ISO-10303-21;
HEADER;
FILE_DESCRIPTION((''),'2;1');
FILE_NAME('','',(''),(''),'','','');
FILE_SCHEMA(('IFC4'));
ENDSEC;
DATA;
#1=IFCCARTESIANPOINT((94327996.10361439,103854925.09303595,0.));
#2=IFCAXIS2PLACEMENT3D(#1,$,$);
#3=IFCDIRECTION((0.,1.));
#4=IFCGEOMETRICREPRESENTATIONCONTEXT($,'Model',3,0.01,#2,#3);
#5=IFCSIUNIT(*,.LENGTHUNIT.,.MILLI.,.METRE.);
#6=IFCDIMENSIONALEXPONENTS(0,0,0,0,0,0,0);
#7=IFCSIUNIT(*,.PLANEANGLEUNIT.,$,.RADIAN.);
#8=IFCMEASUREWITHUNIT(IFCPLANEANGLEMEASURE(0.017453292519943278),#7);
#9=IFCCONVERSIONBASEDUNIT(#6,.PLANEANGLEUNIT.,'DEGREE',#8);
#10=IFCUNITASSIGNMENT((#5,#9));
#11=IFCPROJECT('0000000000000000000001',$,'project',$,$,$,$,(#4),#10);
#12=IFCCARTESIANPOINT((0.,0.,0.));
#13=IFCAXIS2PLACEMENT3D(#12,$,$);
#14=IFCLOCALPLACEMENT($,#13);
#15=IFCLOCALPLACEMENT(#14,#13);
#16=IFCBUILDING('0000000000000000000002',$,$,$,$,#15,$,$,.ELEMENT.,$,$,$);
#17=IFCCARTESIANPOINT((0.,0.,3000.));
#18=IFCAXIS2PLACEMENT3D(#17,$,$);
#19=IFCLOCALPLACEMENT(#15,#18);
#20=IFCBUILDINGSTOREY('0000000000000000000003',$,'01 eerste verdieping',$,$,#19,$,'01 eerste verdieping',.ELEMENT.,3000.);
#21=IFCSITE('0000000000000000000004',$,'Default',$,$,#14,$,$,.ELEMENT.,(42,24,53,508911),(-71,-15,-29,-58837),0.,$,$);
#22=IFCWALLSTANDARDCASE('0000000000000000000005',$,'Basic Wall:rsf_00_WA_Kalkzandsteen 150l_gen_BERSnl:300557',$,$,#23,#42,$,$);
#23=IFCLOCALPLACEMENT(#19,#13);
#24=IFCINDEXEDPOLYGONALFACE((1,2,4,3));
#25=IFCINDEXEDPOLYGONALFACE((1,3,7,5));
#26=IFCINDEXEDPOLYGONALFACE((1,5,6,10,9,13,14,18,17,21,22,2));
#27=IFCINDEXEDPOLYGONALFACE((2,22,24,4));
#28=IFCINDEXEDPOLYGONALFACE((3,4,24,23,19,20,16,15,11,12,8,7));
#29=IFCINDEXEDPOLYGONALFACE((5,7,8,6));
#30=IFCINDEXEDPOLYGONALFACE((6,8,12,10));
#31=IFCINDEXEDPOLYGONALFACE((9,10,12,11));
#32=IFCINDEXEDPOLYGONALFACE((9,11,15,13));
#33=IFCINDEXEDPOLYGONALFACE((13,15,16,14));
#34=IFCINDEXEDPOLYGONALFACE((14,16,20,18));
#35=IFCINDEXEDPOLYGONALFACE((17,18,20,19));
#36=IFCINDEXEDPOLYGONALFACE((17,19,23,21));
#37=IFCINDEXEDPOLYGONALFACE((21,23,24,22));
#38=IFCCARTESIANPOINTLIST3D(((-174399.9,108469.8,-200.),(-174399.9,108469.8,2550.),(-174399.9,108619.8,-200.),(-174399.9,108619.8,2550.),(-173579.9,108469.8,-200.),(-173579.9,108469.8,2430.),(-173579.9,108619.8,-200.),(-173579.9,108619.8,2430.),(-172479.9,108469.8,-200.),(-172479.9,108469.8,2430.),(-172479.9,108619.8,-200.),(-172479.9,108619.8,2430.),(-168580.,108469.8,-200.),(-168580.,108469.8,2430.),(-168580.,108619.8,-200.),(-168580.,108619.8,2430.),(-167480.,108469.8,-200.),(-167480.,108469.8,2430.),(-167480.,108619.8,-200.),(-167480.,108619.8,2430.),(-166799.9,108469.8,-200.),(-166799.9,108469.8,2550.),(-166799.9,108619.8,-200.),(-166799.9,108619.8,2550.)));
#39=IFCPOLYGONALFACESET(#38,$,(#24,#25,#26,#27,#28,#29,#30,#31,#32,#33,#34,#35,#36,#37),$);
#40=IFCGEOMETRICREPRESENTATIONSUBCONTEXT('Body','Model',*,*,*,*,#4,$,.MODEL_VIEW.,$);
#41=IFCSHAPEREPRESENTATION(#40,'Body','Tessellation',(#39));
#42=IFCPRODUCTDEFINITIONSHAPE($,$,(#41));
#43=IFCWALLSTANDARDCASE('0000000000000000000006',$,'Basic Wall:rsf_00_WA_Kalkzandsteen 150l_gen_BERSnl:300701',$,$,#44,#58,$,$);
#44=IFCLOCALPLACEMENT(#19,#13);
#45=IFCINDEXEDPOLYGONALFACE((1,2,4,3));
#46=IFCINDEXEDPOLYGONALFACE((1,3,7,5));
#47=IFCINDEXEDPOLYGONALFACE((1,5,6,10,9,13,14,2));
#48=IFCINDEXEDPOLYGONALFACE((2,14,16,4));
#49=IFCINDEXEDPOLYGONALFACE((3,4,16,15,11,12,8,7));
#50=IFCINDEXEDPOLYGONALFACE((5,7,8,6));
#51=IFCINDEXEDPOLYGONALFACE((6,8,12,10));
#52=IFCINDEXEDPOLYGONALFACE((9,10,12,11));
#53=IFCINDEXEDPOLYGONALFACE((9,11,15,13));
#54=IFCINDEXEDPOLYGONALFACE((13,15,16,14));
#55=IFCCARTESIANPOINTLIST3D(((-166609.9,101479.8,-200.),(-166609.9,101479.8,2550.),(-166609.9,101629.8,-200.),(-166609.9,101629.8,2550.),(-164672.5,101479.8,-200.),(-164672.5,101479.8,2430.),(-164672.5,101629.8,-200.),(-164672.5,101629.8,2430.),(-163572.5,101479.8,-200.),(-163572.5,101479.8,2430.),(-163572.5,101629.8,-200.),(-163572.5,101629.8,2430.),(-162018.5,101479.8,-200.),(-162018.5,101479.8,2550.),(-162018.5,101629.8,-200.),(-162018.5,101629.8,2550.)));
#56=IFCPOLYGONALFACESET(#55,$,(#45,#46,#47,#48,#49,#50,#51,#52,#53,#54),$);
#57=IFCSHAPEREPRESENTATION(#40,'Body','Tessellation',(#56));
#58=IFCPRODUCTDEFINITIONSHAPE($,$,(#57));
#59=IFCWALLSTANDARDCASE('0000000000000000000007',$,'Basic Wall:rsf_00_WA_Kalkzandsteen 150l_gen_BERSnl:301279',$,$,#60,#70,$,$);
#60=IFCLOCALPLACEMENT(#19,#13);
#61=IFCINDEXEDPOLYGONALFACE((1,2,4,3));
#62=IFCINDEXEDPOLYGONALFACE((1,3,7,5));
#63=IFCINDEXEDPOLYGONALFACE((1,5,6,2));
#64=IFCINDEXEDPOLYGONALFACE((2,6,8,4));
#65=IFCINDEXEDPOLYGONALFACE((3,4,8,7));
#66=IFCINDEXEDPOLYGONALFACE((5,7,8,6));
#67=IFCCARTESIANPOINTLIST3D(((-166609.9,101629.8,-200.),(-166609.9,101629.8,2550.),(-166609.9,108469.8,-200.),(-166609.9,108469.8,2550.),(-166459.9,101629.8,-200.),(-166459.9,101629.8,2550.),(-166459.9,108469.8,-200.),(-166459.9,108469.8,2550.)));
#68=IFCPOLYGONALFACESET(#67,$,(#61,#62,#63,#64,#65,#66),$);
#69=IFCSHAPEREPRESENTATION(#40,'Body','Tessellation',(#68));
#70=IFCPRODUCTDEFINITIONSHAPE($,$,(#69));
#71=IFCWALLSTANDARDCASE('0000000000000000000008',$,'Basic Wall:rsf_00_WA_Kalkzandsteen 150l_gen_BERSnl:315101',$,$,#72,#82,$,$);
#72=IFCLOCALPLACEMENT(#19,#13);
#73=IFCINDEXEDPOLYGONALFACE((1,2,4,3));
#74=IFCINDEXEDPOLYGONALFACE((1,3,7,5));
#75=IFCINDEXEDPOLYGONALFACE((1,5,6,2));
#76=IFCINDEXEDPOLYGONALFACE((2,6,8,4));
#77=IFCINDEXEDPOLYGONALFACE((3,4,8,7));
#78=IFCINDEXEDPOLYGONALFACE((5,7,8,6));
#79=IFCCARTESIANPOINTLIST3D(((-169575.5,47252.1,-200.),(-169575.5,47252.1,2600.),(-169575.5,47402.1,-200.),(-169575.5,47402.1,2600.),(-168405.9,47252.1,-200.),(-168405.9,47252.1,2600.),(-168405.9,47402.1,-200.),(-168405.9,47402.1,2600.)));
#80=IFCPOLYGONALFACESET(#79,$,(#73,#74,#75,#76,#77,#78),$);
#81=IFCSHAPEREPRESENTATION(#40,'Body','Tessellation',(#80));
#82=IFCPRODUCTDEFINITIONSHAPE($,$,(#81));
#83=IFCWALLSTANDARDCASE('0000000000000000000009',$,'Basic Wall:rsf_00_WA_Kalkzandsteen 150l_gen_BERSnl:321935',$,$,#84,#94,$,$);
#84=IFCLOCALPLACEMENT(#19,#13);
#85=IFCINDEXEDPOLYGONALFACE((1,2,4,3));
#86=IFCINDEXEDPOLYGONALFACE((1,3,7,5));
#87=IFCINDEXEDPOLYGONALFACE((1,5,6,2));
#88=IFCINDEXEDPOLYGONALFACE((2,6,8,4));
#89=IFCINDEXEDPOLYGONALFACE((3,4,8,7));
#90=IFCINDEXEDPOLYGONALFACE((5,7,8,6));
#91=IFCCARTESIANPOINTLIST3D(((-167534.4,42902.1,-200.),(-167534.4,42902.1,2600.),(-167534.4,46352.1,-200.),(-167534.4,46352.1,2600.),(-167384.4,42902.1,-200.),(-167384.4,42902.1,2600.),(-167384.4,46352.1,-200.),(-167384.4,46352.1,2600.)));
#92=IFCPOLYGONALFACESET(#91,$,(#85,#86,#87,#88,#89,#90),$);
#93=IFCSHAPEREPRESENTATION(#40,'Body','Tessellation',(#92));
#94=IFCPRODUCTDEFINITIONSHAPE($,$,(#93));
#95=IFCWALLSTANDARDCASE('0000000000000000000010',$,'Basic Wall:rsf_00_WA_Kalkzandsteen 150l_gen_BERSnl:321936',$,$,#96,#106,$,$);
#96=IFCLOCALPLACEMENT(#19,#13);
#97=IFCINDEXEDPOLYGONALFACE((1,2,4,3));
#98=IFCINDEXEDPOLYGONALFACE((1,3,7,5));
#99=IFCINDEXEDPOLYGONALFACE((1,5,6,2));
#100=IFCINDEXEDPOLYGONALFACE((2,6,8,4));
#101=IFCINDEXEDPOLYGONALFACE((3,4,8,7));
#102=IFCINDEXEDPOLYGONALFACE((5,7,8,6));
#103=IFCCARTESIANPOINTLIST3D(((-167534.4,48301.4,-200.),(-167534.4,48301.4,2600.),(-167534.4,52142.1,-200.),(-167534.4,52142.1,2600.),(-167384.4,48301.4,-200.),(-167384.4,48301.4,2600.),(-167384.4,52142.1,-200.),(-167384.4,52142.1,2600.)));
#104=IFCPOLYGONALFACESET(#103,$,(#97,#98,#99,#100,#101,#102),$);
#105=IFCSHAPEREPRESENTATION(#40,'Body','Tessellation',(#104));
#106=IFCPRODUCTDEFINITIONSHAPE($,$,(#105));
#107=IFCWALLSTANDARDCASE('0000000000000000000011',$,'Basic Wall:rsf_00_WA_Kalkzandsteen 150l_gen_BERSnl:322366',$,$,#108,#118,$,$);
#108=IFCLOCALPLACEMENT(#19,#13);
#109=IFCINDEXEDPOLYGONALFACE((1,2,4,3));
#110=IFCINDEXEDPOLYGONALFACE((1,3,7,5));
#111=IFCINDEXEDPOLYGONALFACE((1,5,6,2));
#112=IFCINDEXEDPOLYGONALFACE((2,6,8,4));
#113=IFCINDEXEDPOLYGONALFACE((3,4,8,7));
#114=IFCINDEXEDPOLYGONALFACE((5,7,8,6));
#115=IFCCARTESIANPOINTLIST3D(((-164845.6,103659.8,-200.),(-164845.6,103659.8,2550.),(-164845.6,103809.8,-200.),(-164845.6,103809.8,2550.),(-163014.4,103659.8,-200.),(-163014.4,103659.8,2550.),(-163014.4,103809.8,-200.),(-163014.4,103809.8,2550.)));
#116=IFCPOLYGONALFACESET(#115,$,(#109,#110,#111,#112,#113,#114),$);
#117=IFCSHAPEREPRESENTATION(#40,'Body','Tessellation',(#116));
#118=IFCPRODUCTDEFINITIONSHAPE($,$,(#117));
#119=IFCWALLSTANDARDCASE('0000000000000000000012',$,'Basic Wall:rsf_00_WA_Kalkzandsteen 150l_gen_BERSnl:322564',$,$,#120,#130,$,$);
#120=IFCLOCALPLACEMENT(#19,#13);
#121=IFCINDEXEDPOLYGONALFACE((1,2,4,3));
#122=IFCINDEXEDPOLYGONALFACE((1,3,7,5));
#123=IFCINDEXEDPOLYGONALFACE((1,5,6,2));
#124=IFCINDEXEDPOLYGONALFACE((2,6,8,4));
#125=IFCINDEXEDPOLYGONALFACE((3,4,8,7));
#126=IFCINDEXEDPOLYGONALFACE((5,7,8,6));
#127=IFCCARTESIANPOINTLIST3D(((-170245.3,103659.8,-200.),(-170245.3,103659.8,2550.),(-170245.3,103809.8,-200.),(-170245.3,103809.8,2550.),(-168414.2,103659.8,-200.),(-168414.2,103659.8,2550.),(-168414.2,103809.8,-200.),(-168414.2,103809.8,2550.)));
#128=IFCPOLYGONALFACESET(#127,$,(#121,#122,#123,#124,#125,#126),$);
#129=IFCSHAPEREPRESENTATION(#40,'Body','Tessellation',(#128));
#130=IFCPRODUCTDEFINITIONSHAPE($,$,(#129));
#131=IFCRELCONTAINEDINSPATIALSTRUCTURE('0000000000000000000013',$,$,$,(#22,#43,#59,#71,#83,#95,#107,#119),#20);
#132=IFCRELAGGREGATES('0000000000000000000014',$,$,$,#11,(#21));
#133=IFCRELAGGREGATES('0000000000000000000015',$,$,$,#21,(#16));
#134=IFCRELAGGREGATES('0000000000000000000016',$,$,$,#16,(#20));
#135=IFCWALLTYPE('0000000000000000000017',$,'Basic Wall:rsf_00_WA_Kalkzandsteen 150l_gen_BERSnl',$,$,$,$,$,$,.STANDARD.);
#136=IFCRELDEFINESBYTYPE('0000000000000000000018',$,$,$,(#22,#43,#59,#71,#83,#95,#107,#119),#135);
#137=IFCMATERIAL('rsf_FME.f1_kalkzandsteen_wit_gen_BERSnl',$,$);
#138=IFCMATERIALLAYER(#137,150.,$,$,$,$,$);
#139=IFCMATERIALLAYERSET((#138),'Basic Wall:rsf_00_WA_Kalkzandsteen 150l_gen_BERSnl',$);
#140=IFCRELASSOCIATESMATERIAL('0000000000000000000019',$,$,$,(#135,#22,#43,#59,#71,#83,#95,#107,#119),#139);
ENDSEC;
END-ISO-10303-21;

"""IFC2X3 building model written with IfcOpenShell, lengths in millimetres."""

from ifc_helpers import new_model, entity, si_unit, converted_unit, direction, frame, frame_2d, origin, place, context, subcontext, project, spatial, polyline, rectangle, extrude, clip, bounded_halfspace, material, layer, layer_set, layer_usage, type_object, element, save


model = new_model("IFC2X3")

# Units and contexts
model_context = context("Model", 3, precision=0.01, world=frame((94327996.10361439, 103854925.09303595, 0.0)), true_north=direction((0.0, 1.0)))
body_context = subcontext(model_context, "Body", "Model", "MODEL_VIEW")
ifc_project = project(units=[si_unit("LENGTHUNIT", "METRE", prefix="MILLI"), converted_unit("PLANEANGLEUNIT", "DEGREE", entity("IfcPlaneAngleMeasure", 0.017453292519943278), si_unit("PLANEANGLEUNIT", "RADIAN"), dimensions=[0, 0, 0, 0, 0, 0, 0])], contexts=[model_context])

# Site, building, storey
site_placement = place(None, origin())
site = spatial("IfcSite", under=ifc_project, at=site_placement, Name="Default", CompositionType="ELEMENT", RefLatitude=(42, 24, 53, 508911), RefLongitude=(-71, -15, -29, -58837), RefElevation=0.0)
building_placement = place(site_placement, origin())
building = spatial("IfcBuilding", under=site, at=building_placement, CompositionType="ELEMENT")
storey_placement = place(building_placement, frame((0.0, 0.0, 3000.0)))
storey = spatial("IfcBuildingStorey", under=building, at=storey_placement, Name="01 eerste verdieping", LongName="01 eerste verdieping", CompositionType="ELEMENT", Elevation=3000.0)

# Shared definitions
ifc_material = material(Name="rsf_FME.f1_kalkzandsteen_wit_gen_BERSnl")
ifc_layer = layer(ifc_material, 150.0)
ifc_layer_set = layer_set([ifc_layer], Name="Basic Wall:rsf_00_WA_Kalkzandsteen 150l_gen_BERSnl")
wall_type = type_object("IfcWallType", Name="Basic Wall:rsf_00_WA_Kalkzandsteen 150l_gen_BERSnl", PredefinedType="STANDARD", material=ifc_layer_set)

# Wall, openings
ifc_layer_usage_1 = layer_usage(ifc_layer_set, "AXIS2", "NEGATIVE", 75.0)
wall_1_placement = place(storey_placement, frame((-166799.9, 108544.8, -200.0), z_axis=(0.0, 0.0, 1.0), x_axis=(-1.0, 0.0, 0.0)))
wall_1 = element("IfcWallStandardCase", 1, at=wall_1_placement, inside=storey, type_object=wall_type, material=ifc_layer_usage_1, Name="Basic Wall:rsf_00_WA_Kalkzandsteen 150l_gen_BERSnl:300557", context=body_context, shape_type="Clipping", body=[
    clip(extrude(rectangle(XDim=7600.0, YDim=150.0, at=frame_2d((3800.0, 0.0), x_axis=(-1.0, 0.0))), origin(), (0.0, 0.0, 1.0), 2750.0), bounded_halfspace(frame((0.0, -75.0, 2750.0), z_axis=(0.0, 0.0, -1.0), x_axis=(0.0, -1.0, 0.0)), True, frame((0.0, -75.0, 2750.0)), polyline([(0.0, 0.0), (7600.0, 0.0), (7600.0, 150.0), (7450.0, 150.0), (4591.4, 150.0), (4441.4, 150.0), (0.0, 150.0), (0.0, 0.0)]))),
])
opening_1_placement = place(wall_1_placement, frame((-166799.9, 108544.8, 200.0), z_axis=(0.0, 0.0, 1.0), x_axis=(-1.0, 0.0, 0.0)))
element("IfcOpeningElement", 2, at=opening_1_placement, cuts=wall_1, ObjectType="Opening", context=body_context, shape_type="SweptSolid", body=[
    extrude(rectangle(XDim=2630.0, YDim=1100.0, at=frame_2d((0.0, 0.0), x_axis=(1.0, 0.0))), frame((-168030.0, 109993.8, 1115.0), z_axis=(0.0, -1.0, 0.0), x_axis=(0.0, 0.0, 1.0)), (0.0, 0.0, 1.0), 3048.0),
])
opening_2_placement = place(wall_1_placement, frame((-166799.9, 108544.8, 200.0), z_axis=(0.0, 0.0, 1.0), x_axis=(-1.0, 0.0, 0.0)))
element("IfcOpeningElement", 3, at=opening_2_placement, cuts=wall_1, ObjectType="Opening", context=body_context, shape_type="SweptSolid", body=[
    extrude(rectangle(XDim=2630.0, YDim=1100.0, at=frame_2d((0.0, 0.0), x_axis=(0.0, 1.0))), frame((-173029.9, 110143.8, 1115.0), z_axis=(0.0, -1.0, 0.0), x_axis=(1.0, 0.0, 0.0)), (0.0, 0.0, 1.0), 3048.0),
])

# Wall, opening
ifc_layer_usage_2 = layer_usage(ifc_layer_set, "AXIS2", "NEGATIVE", 75.0)
wall_2_placement = place(storey_placement, frame((-166609.9, 101554.8, -200.0)))
wall_2 = element("IfcWallStandardCase", 4, at=wall_2_placement, inside=storey, type_object=wall_type, material=ifc_layer_usage_2, Name="Basic Wall:rsf_00_WA_Kalkzandsteen 150l_gen_BERSnl:300701", context=body_context, shape_type="Clipping", body=[
    clip(extrude(rectangle(XDim=4591.4, YDim=150.0, at=frame_2d((2295.7, 0.0), x_axis=(1.0, 0.0))), origin(), (0.0, 0.0, 1.0), 2750.0), bounded_halfspace(frame((0.0, -75.0, 2750.0), z_axis=(0.0, 0.0, -1.0), x_axis=(0.0, 1.0, 0.0)), True, frame((0.0, -75.0, 2750.0)), polyline([(0.0, 0.0), (4591.4, 0.0), (4591.4, 150.0), (150.0, 150.0), (0.0, 150.0), (0.0, 0.0)]))),
])
opening_3_placement = place(wall_2_placement, frame((166609.9, -101554.8, 200.0)))
element("IfcOpeningElement", 5, at=opening_3_placement, cuts=wall_2, ObjectType="Opening", context=body_context, shape_type="SweptSolid", body=[
    extrude(rectangle(XDim=2630.0, YDim=1100.0, at=frame_2d((0.0, 0.0), x_axis=(0.0, 1.0))), frame((-164122.5, 99955.8, 1115.0), z_axis=(0.0, 1.0, 0.0), x_axis=(-1.0, 0.0, 0.0)), (0.0, 0.0, 1.0), 3048.0),
])

# Wall
ifc_layer_usage_3 = layer_usage(ifc_layer_set, "AXIS2", "NEGATIVE", 75.0)
wall_3_placement = place(storey_placement, frame((-166534.9, 108469.8, -200.0), z_axis=(0.0, 0.0, 1.0), x_axis=(0.0, -1.0, 0.0)))
element("IfcWallStandardCase", 6, at=wall_3_placement, inside=storey, type_object=wall_type, material=ifc_layer_usage_3, Name="Basic Wall:rsf_00_WA_Kalkzandsteen 150l_gen_BERSnl:301279", context=body_context, shape_type="Clipping", body=[
    clip(extrude(rectangle(XDim=6840.0, YDim=150.0, at=frame_2d((3420.0, 0.0), x_axis=(-1.0, 0.0))), origin(), (0.0, 0.0, 1.0), 2750.0), bounded_halfspace(frame((0.0, -75.0, 2750.0), z_axis=(0.0, 0.0, -1.0), x_axis=(-1.0, 0.0, 0.0)), True, frame((0.0, -75.0, 2750.0)), polyline([(0.0, 0.0), (6840.0, 0.0), (6840.0, 150.0), (2710.5, 150.0), (2560.5, 150.0), (0.0, 150.0), (0.0, 0.0)]))),
])

# Walls
ifc_layer_usage_4 = layer_usage(ifc_layer_set, "AXIS2", "POSITIVE", -75.0)
wall_4_placement = place(storey_placement, frame((-168405.9, 47327.1, -200.0), z_axis=(0.0, 0.0, 1.0), x_axis=(-1.0, 0.0, 0.0)))
element("IfcWallStandardCase", 7, at=wall_4_placement, inside=storey, type_object=wall_type, material=ifc_layer_usage_4, Name="Basic Wall:rsf_00_WA_Kalkzandsteen 150l_gen_BERSnl:315101", context=body_context, shape_type="Clipping", body=[
    clip(extrude(rectangle(XDim=1169.6, YDim=150.0, at=frame_2d((584.8, 0.0), x_axis=(-1.0, 0.0))), origin(), (0.0, 0.0, 1.0), 2800.0), bounded_halfspace(frame((0.0, -75.0, 2800.0), z_axis=(0.0, 0.0, -1.0), x_axis=(0.0, -1.0, 0.0)), True, frame((0.0, -75.0, 2800.0)), polyline([(0.0, 0.0), (1169.6, 0.0), (1169.6, 150.0), (0.0, 150.0), (0.0, 0.0)]))),
])
ifc_layer_usage_5 = layer_usage(ifc_layer_set, "AXIS2", "POSITIVE", -75.0)
wall_5_placement = place(storey_placement, frame((-167459.4, 42902.1, -200.0), z_axis=(0.0, 0.0, 1.0), x_axis=(0.0, 1.0, 0.0)))
element("IfcWallStandardCase", 8, at=wall_5_placement, inside=storey, type_object=wall_type, material=ifc_layer_usage_5, Name="Basic Wall:rsf_00_WA_Kalkzandsteen 150l_gen_BERSnl:321935", context=body_context, shape_type="Clipping", body=[
    clip(extrude(rectangle(XDim=3450.0, YDim=150.0, at=frame_2d((1725.0, 0.0), x_axis=(-1.0, 0.0))), origin(), (0.0, 0.0, 1.0), 2800.0), bounded_halfspace(frame((0.0, -75.0, 2800.0), z_axis=(0.0, 0.0, -1.0), x_axis=(1.0, 0.0, 0.0)), True, frame((0.0, -75.0, 2800.0)), polyline([(0.0, 0.0), (3450.0, 0.0), (3450.0, 150.0), (0.0, 150.0), (0.0, 0.0)]))),
])
ifc_layer_usage_6 = layer_usage(ifc_layer_set, "AXIS2", "NEGATIVE", 75.0)
wall_6_placement = place(storey_placement, frame((-167459.4, 52142.1, -200.0), z_axis=(0.0, 0.0, 1.0), x_axis=(0.0, -1.0, 0.0)))
element("IfcWallStandardCase", 9, at=wall_6_placement, inside=storey, type_object=wall_type, material=ifc_layer_usage_6, Name="Basic Wall:rsf_00_WA_Kalkzandsteen 150l_gen_BERSnl:321936", context=body_context, shape_type="SweptSolid", body=[
    extrude(rectangle(XDim=3840.6, YDim=150.0, at=frame_2d((1920.3, 0.0), x_axis=(-1.0, 0.0))), origin(), (0.0, 0.0, 1.0), 2800.0),
])
ifc_layer_usage_7 = layer_usage(ifc_layer_set, "AXIS2", "POSITIVE", -75.0)
wall_7_placement = place(storey_placement, frame((-164845.6, 103734.8, -200.0)))
element("IfcWallStandardCase", 10, at=wall_7_placement, inside=storey, type_object=wall_type, material=ifc_layer_usage_7, Name="Basic Wall:rsf_00_WA_Kalkzandsteen 150l_gen_BERSnl:322366", context=body_context, shape_type="Clipping", body=[
    clip(extrude(rectangle(XDim=1831.2, YDim=150.0, at=frame_2d((915.6, 0.0), x_axis=(-1.0, 0.0))), origin(), (0.0, 0.0, 1.0), 2750.0), bounded_halfspace(frame((0.0, -75.0, 2750.0), z_axis=(0.0, 0.0, -1.0), x_axis=(0.0, 1.0, 0.0)), True, frame((0.0, -75.0, 2750.0)), polyline([(0.0, 0.0), (1831.2, 0.0), (1831.2, 150.0), (0.0, 150.0), (0.0, 0.0)]))),
])
ifc_layer_usage_8 = layer_usage(ifc_layer_set, "AXIS2", "NEGATIVE", 75.0)
wall_8_placement = place(storey_placement, frame((-168414.2, 103734.8, -200.0), z_axis=(0.0, 0.0, 1.0), x_axis=(-1.0, 0.0, 0.0)))
element("IfcWallStandardCase", 11, at=wall_8_placement, inside=storey, type_object=wall_type, material=ifc_layer_usage_8, Name="Basic Wall:rsf_00_WA_Kalkzandsteen 150l_gen_BERSnl:322564", context=body_context, shape_type="Clipping", body=[
    clip(extrude(rectangle(XDim=1831.2, YDim=150.0, at=frame_2d((915.6, 0.0), x_axis=(-1.0, 0.0))), origin(), (0.0, 0.0, 1.0), 2750.0), bounded_halfspace(frame((0.0, -75.0, 2750.0), z_axis=(0.0, 0.0, -1.0), x_axis=(0.0, -1.0, 0.0)), True, frame((0.0, -75.0, 2750.0)), polyline([(0.0, 0.0), (1831.2, 0.0), (1831.2, 150.0), (0.0, 150.0), (0.0, 0.0)]))),
])

save(model, "model.ifc")
